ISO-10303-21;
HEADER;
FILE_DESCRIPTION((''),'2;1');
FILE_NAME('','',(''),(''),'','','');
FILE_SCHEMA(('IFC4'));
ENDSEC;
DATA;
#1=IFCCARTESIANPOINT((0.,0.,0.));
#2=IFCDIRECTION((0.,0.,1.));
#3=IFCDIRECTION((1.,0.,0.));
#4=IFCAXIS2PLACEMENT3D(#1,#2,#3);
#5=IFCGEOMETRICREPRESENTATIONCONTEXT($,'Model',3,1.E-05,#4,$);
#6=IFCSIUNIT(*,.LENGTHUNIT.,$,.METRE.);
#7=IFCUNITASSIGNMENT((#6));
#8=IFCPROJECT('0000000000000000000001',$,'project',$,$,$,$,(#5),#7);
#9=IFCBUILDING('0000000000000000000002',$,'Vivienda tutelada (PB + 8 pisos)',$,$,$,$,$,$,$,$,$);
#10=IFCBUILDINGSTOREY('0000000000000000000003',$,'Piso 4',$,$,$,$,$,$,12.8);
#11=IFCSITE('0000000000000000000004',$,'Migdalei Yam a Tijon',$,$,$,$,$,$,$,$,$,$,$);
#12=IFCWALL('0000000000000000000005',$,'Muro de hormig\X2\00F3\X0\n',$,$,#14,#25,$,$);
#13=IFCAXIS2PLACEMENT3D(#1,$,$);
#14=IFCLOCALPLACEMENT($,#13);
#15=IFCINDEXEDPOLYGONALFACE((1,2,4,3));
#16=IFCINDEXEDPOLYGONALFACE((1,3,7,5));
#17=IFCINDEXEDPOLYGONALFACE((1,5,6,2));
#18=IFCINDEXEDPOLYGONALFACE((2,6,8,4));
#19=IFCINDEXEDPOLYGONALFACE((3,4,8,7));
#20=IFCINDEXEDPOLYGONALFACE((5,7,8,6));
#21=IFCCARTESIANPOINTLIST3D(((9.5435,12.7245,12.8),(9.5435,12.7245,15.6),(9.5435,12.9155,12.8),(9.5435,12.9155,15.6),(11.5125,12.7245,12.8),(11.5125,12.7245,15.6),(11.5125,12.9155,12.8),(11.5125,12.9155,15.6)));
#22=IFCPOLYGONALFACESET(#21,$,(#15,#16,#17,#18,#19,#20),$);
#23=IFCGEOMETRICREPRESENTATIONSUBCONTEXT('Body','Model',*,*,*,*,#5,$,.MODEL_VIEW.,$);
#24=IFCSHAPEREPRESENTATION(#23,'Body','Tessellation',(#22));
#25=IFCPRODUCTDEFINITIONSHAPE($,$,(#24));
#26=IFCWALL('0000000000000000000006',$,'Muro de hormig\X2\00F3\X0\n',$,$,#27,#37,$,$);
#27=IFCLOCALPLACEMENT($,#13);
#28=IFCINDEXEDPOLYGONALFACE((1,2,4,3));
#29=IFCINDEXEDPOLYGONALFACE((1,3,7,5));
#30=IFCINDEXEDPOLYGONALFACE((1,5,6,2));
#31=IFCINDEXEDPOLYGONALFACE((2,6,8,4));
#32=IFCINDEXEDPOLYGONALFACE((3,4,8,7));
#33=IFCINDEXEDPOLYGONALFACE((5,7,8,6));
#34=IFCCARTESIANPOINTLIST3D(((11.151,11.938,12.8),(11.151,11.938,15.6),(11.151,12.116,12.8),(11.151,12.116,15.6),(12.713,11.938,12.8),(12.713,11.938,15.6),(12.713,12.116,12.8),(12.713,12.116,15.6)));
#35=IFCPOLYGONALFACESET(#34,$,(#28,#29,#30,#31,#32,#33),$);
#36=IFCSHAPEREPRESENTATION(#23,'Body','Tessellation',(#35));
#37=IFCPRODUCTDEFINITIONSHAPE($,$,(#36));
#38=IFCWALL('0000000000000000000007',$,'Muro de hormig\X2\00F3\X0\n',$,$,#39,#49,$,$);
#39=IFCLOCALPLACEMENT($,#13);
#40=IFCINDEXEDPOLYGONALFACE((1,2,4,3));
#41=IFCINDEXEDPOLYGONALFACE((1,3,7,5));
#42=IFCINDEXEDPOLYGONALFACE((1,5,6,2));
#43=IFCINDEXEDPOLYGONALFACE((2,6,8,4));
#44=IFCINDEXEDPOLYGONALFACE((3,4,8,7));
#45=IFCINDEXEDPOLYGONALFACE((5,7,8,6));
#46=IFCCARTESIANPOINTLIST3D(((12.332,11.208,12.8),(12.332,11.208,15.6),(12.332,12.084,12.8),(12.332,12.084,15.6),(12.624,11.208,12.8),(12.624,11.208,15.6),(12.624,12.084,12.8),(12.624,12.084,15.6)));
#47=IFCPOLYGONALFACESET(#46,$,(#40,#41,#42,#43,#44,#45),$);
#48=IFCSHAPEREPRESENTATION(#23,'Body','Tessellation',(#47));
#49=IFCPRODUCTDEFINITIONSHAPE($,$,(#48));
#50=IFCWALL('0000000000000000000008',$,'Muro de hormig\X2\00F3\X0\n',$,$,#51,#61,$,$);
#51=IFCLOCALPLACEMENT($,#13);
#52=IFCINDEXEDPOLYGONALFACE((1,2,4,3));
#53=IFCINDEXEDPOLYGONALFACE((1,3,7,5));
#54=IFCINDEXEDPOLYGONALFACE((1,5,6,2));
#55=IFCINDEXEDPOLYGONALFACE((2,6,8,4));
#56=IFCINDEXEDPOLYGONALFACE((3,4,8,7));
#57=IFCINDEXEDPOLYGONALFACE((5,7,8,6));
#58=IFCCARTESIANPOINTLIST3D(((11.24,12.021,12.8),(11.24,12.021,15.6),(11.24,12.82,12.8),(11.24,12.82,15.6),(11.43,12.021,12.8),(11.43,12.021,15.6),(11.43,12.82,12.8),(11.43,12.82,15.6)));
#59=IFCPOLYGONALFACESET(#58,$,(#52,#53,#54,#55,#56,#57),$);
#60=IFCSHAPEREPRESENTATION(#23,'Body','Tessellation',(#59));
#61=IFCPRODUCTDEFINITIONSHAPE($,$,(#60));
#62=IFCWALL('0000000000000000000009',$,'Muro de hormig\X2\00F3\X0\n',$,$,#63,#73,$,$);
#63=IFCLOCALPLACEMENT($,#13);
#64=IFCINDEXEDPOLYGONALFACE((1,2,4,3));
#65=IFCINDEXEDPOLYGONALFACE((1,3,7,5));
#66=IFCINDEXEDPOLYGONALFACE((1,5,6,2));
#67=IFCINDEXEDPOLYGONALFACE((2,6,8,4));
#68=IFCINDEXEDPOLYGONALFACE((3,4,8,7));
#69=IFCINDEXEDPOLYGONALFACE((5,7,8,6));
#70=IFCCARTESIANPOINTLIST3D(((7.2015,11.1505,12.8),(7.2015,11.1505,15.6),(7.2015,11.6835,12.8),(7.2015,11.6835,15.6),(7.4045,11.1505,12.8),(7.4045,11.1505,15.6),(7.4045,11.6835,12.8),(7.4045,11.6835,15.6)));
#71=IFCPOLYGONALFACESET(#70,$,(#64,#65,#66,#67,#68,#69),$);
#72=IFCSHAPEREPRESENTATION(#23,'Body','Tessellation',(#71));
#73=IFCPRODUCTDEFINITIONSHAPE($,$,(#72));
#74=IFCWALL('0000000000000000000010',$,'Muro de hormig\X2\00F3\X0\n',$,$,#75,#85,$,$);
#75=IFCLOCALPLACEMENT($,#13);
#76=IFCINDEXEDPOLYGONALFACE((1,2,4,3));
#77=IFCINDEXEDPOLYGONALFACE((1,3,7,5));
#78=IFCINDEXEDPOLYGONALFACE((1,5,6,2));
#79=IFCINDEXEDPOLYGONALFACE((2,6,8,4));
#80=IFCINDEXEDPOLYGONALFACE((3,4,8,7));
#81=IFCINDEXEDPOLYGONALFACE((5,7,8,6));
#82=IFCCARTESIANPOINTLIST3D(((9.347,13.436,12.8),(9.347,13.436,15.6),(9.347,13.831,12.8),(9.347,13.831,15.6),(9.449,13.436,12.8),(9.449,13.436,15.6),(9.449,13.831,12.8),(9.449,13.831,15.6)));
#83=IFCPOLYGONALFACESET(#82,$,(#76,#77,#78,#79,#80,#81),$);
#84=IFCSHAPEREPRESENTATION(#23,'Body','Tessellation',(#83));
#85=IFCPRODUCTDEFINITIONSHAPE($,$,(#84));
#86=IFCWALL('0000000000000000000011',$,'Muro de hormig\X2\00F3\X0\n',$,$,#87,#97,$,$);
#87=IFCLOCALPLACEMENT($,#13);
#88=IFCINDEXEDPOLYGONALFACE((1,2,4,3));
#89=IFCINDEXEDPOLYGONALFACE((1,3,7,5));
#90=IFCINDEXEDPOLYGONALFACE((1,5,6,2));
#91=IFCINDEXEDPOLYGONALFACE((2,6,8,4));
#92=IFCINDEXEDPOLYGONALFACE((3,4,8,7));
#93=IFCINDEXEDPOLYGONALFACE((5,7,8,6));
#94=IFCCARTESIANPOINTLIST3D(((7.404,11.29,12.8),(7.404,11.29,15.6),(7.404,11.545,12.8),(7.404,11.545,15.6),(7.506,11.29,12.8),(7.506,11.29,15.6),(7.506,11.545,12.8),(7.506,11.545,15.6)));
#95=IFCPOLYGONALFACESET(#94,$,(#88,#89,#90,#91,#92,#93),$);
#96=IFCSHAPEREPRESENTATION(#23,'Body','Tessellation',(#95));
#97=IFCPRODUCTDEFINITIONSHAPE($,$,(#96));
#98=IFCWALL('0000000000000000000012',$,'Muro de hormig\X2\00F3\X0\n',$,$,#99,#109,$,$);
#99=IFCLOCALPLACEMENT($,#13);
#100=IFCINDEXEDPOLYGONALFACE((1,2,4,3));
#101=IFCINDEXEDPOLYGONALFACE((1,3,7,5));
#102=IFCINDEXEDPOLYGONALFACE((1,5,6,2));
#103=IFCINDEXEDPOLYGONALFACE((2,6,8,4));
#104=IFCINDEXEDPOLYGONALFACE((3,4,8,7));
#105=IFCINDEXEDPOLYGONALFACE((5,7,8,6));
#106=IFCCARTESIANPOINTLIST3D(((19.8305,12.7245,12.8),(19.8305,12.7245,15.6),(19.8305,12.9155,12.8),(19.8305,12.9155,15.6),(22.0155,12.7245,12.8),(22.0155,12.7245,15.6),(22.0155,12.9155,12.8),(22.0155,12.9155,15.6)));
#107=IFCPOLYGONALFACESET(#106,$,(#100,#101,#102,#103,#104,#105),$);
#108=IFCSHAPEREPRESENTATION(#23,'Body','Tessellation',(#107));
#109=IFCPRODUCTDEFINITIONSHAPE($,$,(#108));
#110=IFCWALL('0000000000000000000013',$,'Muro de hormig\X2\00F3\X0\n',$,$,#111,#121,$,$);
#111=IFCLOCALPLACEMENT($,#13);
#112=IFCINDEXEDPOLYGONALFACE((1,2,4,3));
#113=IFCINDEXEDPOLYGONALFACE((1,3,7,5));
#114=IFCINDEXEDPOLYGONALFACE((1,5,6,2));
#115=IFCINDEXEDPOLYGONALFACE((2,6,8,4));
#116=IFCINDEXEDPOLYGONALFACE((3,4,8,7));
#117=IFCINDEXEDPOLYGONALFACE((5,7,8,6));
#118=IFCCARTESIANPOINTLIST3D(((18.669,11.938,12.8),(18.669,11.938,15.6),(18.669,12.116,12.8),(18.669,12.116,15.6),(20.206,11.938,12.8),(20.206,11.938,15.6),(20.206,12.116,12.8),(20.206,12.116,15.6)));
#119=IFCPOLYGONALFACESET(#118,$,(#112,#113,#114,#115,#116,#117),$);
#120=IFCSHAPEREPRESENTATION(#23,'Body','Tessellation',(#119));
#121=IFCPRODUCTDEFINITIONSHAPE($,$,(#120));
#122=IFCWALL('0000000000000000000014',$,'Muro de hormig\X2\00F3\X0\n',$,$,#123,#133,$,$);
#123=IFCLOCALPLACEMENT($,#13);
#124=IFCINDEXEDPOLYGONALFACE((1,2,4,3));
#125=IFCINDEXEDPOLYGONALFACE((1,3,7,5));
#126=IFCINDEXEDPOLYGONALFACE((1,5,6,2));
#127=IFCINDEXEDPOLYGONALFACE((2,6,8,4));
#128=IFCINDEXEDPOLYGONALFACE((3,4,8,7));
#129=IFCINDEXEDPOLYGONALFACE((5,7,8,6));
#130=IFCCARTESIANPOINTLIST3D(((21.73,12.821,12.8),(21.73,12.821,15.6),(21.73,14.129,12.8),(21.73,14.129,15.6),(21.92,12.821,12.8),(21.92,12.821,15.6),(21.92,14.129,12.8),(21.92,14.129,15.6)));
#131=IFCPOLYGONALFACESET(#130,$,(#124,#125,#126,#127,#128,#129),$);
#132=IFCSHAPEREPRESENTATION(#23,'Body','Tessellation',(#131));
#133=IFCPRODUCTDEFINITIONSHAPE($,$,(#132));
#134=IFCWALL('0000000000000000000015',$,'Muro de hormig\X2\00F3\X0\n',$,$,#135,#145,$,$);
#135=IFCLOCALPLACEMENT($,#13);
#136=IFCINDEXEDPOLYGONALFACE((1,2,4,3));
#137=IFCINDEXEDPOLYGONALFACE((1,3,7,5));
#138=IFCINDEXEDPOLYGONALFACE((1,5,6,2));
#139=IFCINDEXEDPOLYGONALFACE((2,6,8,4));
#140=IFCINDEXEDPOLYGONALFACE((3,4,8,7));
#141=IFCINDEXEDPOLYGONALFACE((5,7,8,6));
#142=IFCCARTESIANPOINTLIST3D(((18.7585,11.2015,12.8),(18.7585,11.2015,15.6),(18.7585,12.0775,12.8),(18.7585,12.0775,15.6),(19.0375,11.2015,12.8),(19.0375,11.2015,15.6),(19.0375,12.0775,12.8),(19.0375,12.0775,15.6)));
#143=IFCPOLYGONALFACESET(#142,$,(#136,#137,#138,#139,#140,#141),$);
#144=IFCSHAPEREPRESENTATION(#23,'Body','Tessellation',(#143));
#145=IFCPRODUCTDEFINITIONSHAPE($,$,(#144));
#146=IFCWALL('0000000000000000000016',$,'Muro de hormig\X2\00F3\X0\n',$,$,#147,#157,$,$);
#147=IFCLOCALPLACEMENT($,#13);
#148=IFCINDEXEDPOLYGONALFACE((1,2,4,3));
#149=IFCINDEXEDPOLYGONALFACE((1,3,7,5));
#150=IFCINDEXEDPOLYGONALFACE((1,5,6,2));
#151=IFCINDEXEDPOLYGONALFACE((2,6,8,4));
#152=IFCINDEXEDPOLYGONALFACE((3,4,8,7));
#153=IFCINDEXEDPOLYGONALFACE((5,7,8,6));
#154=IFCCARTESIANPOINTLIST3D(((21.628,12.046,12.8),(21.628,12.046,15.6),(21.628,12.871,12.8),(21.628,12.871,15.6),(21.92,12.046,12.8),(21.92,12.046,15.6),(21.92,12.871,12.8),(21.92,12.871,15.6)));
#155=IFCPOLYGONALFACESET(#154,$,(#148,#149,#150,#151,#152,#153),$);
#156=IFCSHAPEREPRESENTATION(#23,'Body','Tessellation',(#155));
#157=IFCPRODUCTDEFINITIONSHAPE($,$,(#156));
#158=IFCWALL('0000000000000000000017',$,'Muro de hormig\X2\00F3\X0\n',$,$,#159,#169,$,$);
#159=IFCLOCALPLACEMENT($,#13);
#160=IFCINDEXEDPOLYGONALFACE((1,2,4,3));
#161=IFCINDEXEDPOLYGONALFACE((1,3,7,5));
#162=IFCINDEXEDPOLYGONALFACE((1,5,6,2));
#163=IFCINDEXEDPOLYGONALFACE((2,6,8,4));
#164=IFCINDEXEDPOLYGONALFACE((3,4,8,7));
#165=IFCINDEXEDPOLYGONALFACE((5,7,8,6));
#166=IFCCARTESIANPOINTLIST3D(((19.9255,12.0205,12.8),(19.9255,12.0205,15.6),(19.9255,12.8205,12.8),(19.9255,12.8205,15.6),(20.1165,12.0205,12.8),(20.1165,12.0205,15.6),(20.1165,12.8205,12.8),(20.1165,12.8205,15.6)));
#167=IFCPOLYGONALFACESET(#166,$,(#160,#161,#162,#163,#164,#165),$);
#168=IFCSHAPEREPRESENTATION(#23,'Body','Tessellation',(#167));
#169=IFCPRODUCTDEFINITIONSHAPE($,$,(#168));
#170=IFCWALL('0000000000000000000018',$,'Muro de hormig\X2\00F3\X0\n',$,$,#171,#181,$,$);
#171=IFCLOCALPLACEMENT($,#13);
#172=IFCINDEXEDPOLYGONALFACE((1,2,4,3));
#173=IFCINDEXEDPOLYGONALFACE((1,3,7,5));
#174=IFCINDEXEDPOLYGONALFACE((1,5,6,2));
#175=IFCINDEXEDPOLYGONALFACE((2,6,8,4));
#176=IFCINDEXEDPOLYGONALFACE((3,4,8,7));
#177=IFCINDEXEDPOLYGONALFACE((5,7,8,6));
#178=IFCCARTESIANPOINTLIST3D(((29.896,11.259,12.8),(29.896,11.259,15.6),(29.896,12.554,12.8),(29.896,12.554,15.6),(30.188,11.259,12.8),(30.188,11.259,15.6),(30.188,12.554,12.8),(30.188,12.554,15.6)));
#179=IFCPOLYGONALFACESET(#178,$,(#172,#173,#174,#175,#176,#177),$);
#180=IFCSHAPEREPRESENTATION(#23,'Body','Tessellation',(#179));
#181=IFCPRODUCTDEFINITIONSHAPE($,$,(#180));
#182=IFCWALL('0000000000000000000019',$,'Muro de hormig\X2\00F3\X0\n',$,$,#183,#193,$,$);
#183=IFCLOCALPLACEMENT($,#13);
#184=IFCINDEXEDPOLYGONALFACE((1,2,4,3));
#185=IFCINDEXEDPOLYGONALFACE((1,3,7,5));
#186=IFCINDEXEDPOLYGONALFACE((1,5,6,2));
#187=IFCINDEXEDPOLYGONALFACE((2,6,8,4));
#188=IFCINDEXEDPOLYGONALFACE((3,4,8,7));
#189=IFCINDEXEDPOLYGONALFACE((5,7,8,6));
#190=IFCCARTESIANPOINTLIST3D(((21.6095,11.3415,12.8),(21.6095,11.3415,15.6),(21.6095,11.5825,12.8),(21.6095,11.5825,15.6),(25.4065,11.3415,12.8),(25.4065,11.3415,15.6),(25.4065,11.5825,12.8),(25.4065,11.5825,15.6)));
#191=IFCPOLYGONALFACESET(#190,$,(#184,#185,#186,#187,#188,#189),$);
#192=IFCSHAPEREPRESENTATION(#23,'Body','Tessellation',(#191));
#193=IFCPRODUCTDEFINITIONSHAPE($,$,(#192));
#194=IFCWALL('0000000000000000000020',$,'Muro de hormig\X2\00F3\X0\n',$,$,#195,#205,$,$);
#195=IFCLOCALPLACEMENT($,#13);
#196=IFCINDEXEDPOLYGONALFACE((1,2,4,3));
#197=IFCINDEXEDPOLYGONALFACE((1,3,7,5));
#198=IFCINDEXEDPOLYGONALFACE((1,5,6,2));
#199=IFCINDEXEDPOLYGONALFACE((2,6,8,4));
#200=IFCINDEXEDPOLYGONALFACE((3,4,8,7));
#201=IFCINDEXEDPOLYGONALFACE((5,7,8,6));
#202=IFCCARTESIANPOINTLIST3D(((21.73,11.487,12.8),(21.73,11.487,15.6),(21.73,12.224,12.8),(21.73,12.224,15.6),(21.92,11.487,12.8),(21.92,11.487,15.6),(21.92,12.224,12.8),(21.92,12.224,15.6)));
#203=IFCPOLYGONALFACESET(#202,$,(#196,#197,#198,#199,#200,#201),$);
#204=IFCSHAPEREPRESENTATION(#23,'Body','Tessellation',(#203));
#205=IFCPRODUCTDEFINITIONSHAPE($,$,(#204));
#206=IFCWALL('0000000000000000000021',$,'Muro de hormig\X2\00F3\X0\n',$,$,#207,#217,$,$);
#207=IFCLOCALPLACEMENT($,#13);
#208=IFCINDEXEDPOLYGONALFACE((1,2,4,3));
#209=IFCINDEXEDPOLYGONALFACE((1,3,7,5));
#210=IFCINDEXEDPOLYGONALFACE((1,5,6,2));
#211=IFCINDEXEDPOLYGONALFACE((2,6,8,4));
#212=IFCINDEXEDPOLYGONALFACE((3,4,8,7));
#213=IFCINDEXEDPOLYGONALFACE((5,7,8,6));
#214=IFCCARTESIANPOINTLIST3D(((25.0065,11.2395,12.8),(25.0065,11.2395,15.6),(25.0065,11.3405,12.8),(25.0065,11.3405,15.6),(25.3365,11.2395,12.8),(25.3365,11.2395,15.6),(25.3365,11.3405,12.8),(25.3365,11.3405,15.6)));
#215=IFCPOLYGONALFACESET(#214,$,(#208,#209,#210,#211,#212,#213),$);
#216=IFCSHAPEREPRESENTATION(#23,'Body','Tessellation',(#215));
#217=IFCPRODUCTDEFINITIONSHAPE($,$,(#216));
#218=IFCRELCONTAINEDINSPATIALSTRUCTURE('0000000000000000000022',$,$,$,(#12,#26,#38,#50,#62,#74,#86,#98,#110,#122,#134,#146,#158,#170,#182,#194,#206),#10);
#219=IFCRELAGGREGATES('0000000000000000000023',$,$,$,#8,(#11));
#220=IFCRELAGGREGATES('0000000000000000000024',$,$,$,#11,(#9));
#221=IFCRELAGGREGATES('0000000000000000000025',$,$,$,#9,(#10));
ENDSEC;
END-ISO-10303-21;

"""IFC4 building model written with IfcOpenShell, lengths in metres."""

from ifc_helpers import new_model, si_unit, frame, origin_with_axes, context, subcontext, project, spatial, line, indexed_curve, outline, extrude, element, save


model = new_model("IFC4")

# Units and contexts
model_context = context("Model", 3, precision=1e-05, world=origin_with_axes())
body_context = subcontext(model_context, "Body", "Model", "MODEL_VIEW")
ifc_project = project(units=[si_unit("LENGTHUNIT", "METRE")], contexts=[model_context])

# Site, building, storey
site = spatial("IfcSite", under=ifc_project, Name="Migdalei Yam a Tijon")
building = spatial("IfcBuilding", under=site, Name="Vivienda tutelada (PB + 8 pisos)")
storey = spatial("IfcBuildingStorey", under=building, Name="Piso 4", Elevation=12.8)

# Walls
element("IfcWall", 1, inside=storey, Name="Muro de hormigón", context=body_context, shape_type="SweptSolid", body=[
    extrude(outline(indexed_curve([(0.0, 0.0), (1.969, 0.0), (1.969, 0.191), (0.0, 0.191)], segments=[line(1, 2, 3, 4, 1)])), frame((9.5435, 12.7245, 12.8), z_axis=(0.0, 0.0, 1.0), x_axis=(1.0, 0.0, 0.0)), (0.0, 0.0, 1.0), 2.8),
])
element("IfcWall", 2, inside=storey, Name="Muro de hormigón", context=body_context, shape_type="SweptSolid", body=[
    extrude(outline(indexed_curve([(0.0, 0.0), (1.562, 0.0), (1.562, 0.178), (0.0, 0.178)], segments=[line(1, 2, 3, 4, 1)])), frame((11.151, 11.938, 12.8), z_axis=(0.0, 0.0, 1.0), x_axis=(1.0, 0.0, 0.0)), (0.0, 0.0, 1.0), 2.8),
])
element("IfcWall", 3, inside=storey, Name="Muro de hormigón", context=body_context, shape_type="SweptSolid", body=[
    extrude(outline(indexed_curve([(0.0, 0.0), (0.292, 0.0), (0.292, 0.876), (0.0, 0.876)], segments=[line(1, 2, 3, 4, 1)])), frame((12.332, 11.208, 12.8), z_axis=(0.0, 0.0, 1.0), x_axis=(1.0, 0.0, 0.0)), (0.0, 0.0, 1.0), 2.8),
])
element("IfcWall", 4, inside=storey, Name="Muro de hormigón", context=body_context, shape_type="SweptSolid", body=[
    extrude(outline(indexed_curve([(0.0, 0.0), (0.19, 0.0), (0.19, 0.799), (0.0, 0.799)], segments=[line(1, 2, 3, 4, 1)])), frame((11.24, 12.021, 12.8), z_axis=(0.0, 0.0, 1.0), x_axis=(1.0, 0.0, 0.0)), (0.0, 0.0, 1.0), 2.8),
])
element("IfcWall", 5, inside=storey, Name="Muro de hormigón", context=body_context, shape_type="SweptSolid", body=[
    extrude(outline(indexed_curve([(0.0, 0.0), (0.203, 0.0), (0.203, 0.533), (0.0, 0.533)], segments=[line(1, 2, 3, 4, 1)])), frame((7.2015, 11.1505, 12.8), z_axis=(0.0, 0.0, 1.0), x_axis=(1.0, 0.0, 0.0)), (0.0, 0.0, 1.0), 2.8),
])
element("IfcWall", 6, inside=storey, Name="Muro de hormigón", context=body_context, shape_type="SweptSolid", body=[
    extrude(outline(indexed_curve([(0.0, 0.0), (0.102, 0.0), (0.102, 0.395), (0.0, 0.395)], segments=[line(1, 2, 3, 4, 1)])), frame((9.347, 13.436, 12.8), z_axis=(0.0, 0.0, 1.0), x_axis=(1.0, 0.0, 0.0)), (0.0, 0.0, 1.0), 2.8),
])
element("IfcWall", 7, inside=storey, Name="Muro de hormigón", context=body_context, shape_type="SweptSolid", body=[
    extrude(outline(indexed_curve([(0.0, 0.0), (0.102, 0.0), (0.102, 0.255), (0.0, 0.255)], segments=[line(1, 2, 3, 4, 1)])), frame((7.404, 11.29, 12.8), z_axis=(0.0, 0.0, 1.0), x_axis=(1.0, 0.0, 0.0)), (0.0, 0.0, 1.0), 2.8),
])
element("IfcWall", 8, inside=storey, Name="Muro de hormigón", context=body_context, shape_type="SweptSolid", body=[
    extrude(outline(indexed_curve([(0.0, 0.0), (2.185, 0.0), (2.185, 0.191), (0.0, 0.191)], segments=[line(1, 2, 3, 4, 1)])), frame((19.8305, 12.7245, 12.8), z_axis=(0.0, 0.0, 1.0), x_axis=(1.0, 0.0, 0.0)), (0.0, 0.0, 1.0), 2.8),
])
element("IfcWall", 9, inside=storey, Name="Muro de hormigón", context=body_context, shape_type="SweptSolid", body=[
    extrude(outline(indexed_curve([(0.0, 0.0), (1.537, 0.0), (1.537, 0.178), (0.0, 0.178)], segments=[line(1, 2, 3, 4, 1)])), frame((18.669, 11.938, 12.8), z_axis=(0.0, 0.0, 1.0), x_axis=(1.0, 0.0, 0.0)), (0.0, 0.0, 1.0), 2.8),
])
element("IfcWall", 10, inside=storey, Name="Muro de hormigón", context=body_context, shape_type="SweptSolid", body=[
    extrude(outline(indexed_curve([(0.0, 0.0), (0.19, 0.0), (0.19, 1.308), (0.0, 1.308)], segments=[line(1, 2, 3, 4, 1)])), frame((21.73, 12.821, 12.8), z_axis=(0.0, 0.0, 1.0), x_axis=(1.0, 0.0, 0.0)), (0.0, 0.0, 1.0), 2.8),
])
element("IfcWall", 11, inside=storey, Name="Muro de hormigón", context=body_context, shape_type="SweptSolid", body=[
    extrude(outline(indexed_curve([(0.0, 0.0), (0.279, 0.0), (0.279, 0.876), (0.0, 0.876)], segments=[line(1, 2, 3, 4, 1)])), frame((18.7585, 11.2015, 12.8), z_axis=(0.0, 0.0, 1.0), x_axis=(1.0, 0.0, 0.0)), (0.0, 0.0, 1.0), 2.8),
])
element("IfcWall", 12, inside=storey, Name="Muro de hormigón", context=body_context, shape_type="SweptSolid", body=[
    extrude(outline(indexed_curve([(0.0, 0.0), (0.292, 0.0), (0.292, 0.825), (0.0, 0.825)], segments=[line(1, 2, 3, 4, 1)])), frame((21.628, 12.046, 12.8), z_axis=(0.0, 0.0, 1.0), x_axis=(1.0, 0.0, 0.0)), (0.0, 0.0, 1.0), 2.8),
])
element("IfcWall", 13, inside=storey, Name="Muro de hormigón", context=body_context, shape_type="SweptSolid", body=[
    extrude(outline(indexed_curve([(0.0, 0.0), (0.191, 0.0), (0.191, 0.8), (0.0, 0.8)], segments=[line(1, 2, 3, 4, 1)])), frame((19.9255, 12.0205, 12.8), z_axis=(0.0, 0.0, 1.0), x_axis=(1.0, 0.0, 0.0)), (0.0, 0.0, 1.0), 2.8),
])
element("IfcWall", 14, inside=storey, Name="Muro de hormigón", context=body_context, shape_type="SweptSolid", body=[
    extrude(outline(indexed_curve([(0.0, 0.0), (0.292, 0.0), (0.292, 1.295), (0.0, 1.295)], segments=[line(1, 2, 3, 4, 1)])), frame((29.896, 11.259, 12.8), z_axis=(0.0, 0.0, 1.0), x_axis=(1.0, 0.0, 0.0)), (0.0, 0.0, 1.0), 2.8),
])
element("IfcWall", 15, inside=storey, Name="Muro de hormigón", context=body_context, shape_type="SweptSolid", body=[
    extrude(outline(indexed_curve([(0.0, 0.0), (3.797, 0.0), (3.797, 0.241), (0.0, 0.241)], segments=[line(1, 2, 3, 4, 1)])), frame((21.6095, 11.3415, 12.8), z_axis=(0.0, 0.0, 1.0), x_axis=(1.0, 0.0, 0.0)), (0.0, 0.0, 1.0), 2.8),
])
element("IfcWall", 16, inside=storey, Name="Muro de hormigón", context=body_context, shape_type="SweptSolid", body=[
    extrude(outline(indexed_curve([(0.0, 0.0), (0.19, 0.0), (0.19, 0.737), (0.0, 0.737)], segments=[line(1, 2, 3, 4, 1)])), frame((21.73, 11.487, 12.8), z_axis=(0.0, 0.0, 1.0), x_axis=(1.0, 0.0, 0.0)), (0.0, 0.0, 1.0), 2.8),
])
element("IfcWall", 17, inside=storey, Name="Muro de hormigón", context=body_context, shape_type="SweptSolid", body=[
    extrude(outline(indexed_curve([(0.0, 0.0), (0.33, 0.0), (0.33, 0.101), (0.0, 0.101)], segments=[line(1, 2, 3, 4, 1)])), frame((25.0065, 11.2395, 12.8), z_axis=(0.0, 0.0, 1.0), x_axis=(1.0, 0.0, 0.0)), (0.0, 0.0, 1.0), 2.8),
])

save(model, "model.ifc")
